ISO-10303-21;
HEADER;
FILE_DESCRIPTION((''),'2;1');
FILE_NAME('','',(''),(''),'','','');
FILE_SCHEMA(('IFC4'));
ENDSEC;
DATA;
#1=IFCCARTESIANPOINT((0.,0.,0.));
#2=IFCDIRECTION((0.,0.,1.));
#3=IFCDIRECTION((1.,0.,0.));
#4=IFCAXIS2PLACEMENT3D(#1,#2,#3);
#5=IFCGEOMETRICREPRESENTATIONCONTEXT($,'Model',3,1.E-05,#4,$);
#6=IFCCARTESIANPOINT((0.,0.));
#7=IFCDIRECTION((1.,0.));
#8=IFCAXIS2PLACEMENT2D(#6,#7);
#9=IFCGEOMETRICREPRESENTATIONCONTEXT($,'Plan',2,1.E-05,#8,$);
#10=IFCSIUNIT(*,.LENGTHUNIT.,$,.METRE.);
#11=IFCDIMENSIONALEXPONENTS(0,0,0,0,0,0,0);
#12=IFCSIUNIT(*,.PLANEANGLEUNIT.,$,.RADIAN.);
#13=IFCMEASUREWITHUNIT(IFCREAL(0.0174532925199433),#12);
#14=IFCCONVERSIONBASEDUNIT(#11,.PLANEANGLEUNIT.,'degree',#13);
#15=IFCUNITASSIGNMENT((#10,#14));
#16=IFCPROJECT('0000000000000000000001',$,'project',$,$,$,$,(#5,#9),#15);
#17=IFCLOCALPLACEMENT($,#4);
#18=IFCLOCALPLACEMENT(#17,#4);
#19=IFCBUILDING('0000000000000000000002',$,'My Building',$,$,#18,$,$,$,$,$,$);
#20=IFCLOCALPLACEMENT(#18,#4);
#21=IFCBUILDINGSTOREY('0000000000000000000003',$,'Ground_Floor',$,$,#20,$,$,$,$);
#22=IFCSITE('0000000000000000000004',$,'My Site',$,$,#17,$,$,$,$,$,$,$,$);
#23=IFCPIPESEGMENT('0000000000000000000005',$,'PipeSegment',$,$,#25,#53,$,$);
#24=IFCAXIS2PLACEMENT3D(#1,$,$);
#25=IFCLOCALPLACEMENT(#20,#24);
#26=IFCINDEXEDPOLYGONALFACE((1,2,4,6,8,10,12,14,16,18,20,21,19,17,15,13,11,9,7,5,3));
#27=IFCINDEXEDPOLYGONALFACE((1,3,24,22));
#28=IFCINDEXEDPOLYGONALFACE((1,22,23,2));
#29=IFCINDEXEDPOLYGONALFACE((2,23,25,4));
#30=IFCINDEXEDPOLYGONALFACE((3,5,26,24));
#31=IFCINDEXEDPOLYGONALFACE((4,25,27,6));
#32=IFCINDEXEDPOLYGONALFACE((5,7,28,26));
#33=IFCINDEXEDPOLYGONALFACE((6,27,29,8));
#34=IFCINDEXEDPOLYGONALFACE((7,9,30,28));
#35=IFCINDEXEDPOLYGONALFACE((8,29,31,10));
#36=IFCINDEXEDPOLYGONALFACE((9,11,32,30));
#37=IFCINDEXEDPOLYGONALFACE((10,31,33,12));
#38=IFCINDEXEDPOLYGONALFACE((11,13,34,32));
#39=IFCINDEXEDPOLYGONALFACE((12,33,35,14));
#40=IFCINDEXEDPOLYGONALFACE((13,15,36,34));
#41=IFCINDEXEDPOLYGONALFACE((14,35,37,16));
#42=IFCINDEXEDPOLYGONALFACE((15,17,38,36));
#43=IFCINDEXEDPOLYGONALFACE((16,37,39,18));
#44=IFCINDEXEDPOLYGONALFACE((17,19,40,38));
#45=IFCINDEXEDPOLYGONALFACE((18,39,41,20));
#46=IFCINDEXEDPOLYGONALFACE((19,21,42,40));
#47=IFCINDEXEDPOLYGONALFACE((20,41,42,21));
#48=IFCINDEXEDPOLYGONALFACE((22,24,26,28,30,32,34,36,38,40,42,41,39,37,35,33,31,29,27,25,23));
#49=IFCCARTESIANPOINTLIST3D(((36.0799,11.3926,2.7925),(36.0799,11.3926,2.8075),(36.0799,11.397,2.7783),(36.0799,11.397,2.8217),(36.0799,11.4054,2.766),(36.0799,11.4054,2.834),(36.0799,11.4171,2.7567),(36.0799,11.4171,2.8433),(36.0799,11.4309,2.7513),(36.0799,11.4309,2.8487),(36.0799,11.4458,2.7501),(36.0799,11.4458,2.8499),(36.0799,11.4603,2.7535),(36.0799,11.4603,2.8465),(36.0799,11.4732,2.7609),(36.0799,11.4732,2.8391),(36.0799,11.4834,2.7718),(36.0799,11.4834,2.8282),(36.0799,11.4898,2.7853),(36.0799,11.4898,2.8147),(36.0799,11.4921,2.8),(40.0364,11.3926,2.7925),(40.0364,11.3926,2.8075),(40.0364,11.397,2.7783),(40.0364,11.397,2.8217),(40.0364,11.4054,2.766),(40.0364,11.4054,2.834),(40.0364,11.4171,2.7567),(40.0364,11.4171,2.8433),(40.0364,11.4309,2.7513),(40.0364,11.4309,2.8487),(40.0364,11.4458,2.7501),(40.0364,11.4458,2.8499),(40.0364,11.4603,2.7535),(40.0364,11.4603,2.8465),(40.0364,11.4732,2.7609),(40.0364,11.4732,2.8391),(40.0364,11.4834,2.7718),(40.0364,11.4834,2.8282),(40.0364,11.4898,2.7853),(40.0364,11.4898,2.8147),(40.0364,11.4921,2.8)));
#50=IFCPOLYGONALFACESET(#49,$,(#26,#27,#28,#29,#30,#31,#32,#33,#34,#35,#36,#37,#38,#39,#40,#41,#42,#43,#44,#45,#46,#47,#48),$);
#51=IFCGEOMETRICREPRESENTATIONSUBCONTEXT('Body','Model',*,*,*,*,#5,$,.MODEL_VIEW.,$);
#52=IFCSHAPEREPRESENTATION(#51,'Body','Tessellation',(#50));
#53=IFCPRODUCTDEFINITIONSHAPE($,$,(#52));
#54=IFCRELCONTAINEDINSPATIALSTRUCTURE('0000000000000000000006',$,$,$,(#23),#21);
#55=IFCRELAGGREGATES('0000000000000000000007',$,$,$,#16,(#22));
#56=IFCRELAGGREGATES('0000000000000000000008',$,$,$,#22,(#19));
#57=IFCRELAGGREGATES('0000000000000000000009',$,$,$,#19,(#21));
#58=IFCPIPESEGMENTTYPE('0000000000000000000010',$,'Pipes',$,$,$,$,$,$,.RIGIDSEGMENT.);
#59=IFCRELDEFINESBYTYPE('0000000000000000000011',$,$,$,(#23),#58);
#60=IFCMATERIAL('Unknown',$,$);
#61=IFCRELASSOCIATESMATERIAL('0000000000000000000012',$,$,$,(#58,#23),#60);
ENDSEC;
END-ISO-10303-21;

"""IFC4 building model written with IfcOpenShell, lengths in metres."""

from ifc_helpers import new_model, entity, si_unit, converted_unit, frame, origin_with_axes, origin_2d_with_axis, place, context, subcontext, project, spatial, circle, extrude, material, material_profile, profile_set, profile_usage, type_object, element, save


model = new_model("IFC4")

# Units and contexts
model_context = context("Model", 3, precision=1e-05, world=origin_with_axes())
plan_context = context("Plan", 2, precision=1e-05, world=origin_2d_with_axis())
body_context = subcontext(model_context, "Body", "Model", "MODEL_VIEW")
ifc_project = project(units=[si_unit("LENGTHUNIT", "METRE"), converted_unit("PLANEANGLEUNIT", "degree", entity("IfcReal", 0.0174532925199433), si_unit("PLANEANGLEUNIT", "RADIAN"), dimensions=[0, 0, 0, 0, 0, 0, 0])], contexts=[model_context, plan_context])

# Site, building, storey
site_placement = place(None, origin_with_axes())
site = spatial("IfcSite", under=ifc_project, at=site_placement, Name="My Site")
building_placement = place(site_placement, origin_with_axes())
building = spatial("IfcBuilding", under=site, at=building_placement, Name="My Building")
storey_placement = place(building_placement, origin_with_axes())
storey = spatial("IfcBuildingStorey", under=building, at=storey_placement, Name="Ground_Floor")

# Shared definitions
ifc_material = material(Name="Unknown")

# Pipe segment
ifc_material_profile_1 = material_profile(ifc_material, circle(Radius=0.05))
ifc_profile_set_1 = profile_set([ifc_material_profile_1])
pipe_segment_type = type_object("IfcPipeSegmentType", Name="Pipes", PredefinedType="RIGIDSEGMENT", material=ifc_profile_set_1)
ifc_profile_usage_1 = profile_usage(ifc_profile_set_1, cardinal=5)
pipe_segment_1_placement = place(storey_placement, frame((36.0799, 11.4421, 2.8), z_axis=(1.0, 0.0, 0.0), x_axis=(0.0, 1.0, 0.0)))
element("IfcPipeSegment", 1, at=pipe_segment_1_placement, inside=storey, type_object=pipe_segment_type, material=ifc_profile_usage_1, Name="PipeSegment", context=body_context, shape_type="SweptSolid", body=[
    extrude(circle(Radius=0.05), origin_with_axes(), (0.0, 0.0, 1.0), 3.9565),
])

save(model, "model.ifc")
